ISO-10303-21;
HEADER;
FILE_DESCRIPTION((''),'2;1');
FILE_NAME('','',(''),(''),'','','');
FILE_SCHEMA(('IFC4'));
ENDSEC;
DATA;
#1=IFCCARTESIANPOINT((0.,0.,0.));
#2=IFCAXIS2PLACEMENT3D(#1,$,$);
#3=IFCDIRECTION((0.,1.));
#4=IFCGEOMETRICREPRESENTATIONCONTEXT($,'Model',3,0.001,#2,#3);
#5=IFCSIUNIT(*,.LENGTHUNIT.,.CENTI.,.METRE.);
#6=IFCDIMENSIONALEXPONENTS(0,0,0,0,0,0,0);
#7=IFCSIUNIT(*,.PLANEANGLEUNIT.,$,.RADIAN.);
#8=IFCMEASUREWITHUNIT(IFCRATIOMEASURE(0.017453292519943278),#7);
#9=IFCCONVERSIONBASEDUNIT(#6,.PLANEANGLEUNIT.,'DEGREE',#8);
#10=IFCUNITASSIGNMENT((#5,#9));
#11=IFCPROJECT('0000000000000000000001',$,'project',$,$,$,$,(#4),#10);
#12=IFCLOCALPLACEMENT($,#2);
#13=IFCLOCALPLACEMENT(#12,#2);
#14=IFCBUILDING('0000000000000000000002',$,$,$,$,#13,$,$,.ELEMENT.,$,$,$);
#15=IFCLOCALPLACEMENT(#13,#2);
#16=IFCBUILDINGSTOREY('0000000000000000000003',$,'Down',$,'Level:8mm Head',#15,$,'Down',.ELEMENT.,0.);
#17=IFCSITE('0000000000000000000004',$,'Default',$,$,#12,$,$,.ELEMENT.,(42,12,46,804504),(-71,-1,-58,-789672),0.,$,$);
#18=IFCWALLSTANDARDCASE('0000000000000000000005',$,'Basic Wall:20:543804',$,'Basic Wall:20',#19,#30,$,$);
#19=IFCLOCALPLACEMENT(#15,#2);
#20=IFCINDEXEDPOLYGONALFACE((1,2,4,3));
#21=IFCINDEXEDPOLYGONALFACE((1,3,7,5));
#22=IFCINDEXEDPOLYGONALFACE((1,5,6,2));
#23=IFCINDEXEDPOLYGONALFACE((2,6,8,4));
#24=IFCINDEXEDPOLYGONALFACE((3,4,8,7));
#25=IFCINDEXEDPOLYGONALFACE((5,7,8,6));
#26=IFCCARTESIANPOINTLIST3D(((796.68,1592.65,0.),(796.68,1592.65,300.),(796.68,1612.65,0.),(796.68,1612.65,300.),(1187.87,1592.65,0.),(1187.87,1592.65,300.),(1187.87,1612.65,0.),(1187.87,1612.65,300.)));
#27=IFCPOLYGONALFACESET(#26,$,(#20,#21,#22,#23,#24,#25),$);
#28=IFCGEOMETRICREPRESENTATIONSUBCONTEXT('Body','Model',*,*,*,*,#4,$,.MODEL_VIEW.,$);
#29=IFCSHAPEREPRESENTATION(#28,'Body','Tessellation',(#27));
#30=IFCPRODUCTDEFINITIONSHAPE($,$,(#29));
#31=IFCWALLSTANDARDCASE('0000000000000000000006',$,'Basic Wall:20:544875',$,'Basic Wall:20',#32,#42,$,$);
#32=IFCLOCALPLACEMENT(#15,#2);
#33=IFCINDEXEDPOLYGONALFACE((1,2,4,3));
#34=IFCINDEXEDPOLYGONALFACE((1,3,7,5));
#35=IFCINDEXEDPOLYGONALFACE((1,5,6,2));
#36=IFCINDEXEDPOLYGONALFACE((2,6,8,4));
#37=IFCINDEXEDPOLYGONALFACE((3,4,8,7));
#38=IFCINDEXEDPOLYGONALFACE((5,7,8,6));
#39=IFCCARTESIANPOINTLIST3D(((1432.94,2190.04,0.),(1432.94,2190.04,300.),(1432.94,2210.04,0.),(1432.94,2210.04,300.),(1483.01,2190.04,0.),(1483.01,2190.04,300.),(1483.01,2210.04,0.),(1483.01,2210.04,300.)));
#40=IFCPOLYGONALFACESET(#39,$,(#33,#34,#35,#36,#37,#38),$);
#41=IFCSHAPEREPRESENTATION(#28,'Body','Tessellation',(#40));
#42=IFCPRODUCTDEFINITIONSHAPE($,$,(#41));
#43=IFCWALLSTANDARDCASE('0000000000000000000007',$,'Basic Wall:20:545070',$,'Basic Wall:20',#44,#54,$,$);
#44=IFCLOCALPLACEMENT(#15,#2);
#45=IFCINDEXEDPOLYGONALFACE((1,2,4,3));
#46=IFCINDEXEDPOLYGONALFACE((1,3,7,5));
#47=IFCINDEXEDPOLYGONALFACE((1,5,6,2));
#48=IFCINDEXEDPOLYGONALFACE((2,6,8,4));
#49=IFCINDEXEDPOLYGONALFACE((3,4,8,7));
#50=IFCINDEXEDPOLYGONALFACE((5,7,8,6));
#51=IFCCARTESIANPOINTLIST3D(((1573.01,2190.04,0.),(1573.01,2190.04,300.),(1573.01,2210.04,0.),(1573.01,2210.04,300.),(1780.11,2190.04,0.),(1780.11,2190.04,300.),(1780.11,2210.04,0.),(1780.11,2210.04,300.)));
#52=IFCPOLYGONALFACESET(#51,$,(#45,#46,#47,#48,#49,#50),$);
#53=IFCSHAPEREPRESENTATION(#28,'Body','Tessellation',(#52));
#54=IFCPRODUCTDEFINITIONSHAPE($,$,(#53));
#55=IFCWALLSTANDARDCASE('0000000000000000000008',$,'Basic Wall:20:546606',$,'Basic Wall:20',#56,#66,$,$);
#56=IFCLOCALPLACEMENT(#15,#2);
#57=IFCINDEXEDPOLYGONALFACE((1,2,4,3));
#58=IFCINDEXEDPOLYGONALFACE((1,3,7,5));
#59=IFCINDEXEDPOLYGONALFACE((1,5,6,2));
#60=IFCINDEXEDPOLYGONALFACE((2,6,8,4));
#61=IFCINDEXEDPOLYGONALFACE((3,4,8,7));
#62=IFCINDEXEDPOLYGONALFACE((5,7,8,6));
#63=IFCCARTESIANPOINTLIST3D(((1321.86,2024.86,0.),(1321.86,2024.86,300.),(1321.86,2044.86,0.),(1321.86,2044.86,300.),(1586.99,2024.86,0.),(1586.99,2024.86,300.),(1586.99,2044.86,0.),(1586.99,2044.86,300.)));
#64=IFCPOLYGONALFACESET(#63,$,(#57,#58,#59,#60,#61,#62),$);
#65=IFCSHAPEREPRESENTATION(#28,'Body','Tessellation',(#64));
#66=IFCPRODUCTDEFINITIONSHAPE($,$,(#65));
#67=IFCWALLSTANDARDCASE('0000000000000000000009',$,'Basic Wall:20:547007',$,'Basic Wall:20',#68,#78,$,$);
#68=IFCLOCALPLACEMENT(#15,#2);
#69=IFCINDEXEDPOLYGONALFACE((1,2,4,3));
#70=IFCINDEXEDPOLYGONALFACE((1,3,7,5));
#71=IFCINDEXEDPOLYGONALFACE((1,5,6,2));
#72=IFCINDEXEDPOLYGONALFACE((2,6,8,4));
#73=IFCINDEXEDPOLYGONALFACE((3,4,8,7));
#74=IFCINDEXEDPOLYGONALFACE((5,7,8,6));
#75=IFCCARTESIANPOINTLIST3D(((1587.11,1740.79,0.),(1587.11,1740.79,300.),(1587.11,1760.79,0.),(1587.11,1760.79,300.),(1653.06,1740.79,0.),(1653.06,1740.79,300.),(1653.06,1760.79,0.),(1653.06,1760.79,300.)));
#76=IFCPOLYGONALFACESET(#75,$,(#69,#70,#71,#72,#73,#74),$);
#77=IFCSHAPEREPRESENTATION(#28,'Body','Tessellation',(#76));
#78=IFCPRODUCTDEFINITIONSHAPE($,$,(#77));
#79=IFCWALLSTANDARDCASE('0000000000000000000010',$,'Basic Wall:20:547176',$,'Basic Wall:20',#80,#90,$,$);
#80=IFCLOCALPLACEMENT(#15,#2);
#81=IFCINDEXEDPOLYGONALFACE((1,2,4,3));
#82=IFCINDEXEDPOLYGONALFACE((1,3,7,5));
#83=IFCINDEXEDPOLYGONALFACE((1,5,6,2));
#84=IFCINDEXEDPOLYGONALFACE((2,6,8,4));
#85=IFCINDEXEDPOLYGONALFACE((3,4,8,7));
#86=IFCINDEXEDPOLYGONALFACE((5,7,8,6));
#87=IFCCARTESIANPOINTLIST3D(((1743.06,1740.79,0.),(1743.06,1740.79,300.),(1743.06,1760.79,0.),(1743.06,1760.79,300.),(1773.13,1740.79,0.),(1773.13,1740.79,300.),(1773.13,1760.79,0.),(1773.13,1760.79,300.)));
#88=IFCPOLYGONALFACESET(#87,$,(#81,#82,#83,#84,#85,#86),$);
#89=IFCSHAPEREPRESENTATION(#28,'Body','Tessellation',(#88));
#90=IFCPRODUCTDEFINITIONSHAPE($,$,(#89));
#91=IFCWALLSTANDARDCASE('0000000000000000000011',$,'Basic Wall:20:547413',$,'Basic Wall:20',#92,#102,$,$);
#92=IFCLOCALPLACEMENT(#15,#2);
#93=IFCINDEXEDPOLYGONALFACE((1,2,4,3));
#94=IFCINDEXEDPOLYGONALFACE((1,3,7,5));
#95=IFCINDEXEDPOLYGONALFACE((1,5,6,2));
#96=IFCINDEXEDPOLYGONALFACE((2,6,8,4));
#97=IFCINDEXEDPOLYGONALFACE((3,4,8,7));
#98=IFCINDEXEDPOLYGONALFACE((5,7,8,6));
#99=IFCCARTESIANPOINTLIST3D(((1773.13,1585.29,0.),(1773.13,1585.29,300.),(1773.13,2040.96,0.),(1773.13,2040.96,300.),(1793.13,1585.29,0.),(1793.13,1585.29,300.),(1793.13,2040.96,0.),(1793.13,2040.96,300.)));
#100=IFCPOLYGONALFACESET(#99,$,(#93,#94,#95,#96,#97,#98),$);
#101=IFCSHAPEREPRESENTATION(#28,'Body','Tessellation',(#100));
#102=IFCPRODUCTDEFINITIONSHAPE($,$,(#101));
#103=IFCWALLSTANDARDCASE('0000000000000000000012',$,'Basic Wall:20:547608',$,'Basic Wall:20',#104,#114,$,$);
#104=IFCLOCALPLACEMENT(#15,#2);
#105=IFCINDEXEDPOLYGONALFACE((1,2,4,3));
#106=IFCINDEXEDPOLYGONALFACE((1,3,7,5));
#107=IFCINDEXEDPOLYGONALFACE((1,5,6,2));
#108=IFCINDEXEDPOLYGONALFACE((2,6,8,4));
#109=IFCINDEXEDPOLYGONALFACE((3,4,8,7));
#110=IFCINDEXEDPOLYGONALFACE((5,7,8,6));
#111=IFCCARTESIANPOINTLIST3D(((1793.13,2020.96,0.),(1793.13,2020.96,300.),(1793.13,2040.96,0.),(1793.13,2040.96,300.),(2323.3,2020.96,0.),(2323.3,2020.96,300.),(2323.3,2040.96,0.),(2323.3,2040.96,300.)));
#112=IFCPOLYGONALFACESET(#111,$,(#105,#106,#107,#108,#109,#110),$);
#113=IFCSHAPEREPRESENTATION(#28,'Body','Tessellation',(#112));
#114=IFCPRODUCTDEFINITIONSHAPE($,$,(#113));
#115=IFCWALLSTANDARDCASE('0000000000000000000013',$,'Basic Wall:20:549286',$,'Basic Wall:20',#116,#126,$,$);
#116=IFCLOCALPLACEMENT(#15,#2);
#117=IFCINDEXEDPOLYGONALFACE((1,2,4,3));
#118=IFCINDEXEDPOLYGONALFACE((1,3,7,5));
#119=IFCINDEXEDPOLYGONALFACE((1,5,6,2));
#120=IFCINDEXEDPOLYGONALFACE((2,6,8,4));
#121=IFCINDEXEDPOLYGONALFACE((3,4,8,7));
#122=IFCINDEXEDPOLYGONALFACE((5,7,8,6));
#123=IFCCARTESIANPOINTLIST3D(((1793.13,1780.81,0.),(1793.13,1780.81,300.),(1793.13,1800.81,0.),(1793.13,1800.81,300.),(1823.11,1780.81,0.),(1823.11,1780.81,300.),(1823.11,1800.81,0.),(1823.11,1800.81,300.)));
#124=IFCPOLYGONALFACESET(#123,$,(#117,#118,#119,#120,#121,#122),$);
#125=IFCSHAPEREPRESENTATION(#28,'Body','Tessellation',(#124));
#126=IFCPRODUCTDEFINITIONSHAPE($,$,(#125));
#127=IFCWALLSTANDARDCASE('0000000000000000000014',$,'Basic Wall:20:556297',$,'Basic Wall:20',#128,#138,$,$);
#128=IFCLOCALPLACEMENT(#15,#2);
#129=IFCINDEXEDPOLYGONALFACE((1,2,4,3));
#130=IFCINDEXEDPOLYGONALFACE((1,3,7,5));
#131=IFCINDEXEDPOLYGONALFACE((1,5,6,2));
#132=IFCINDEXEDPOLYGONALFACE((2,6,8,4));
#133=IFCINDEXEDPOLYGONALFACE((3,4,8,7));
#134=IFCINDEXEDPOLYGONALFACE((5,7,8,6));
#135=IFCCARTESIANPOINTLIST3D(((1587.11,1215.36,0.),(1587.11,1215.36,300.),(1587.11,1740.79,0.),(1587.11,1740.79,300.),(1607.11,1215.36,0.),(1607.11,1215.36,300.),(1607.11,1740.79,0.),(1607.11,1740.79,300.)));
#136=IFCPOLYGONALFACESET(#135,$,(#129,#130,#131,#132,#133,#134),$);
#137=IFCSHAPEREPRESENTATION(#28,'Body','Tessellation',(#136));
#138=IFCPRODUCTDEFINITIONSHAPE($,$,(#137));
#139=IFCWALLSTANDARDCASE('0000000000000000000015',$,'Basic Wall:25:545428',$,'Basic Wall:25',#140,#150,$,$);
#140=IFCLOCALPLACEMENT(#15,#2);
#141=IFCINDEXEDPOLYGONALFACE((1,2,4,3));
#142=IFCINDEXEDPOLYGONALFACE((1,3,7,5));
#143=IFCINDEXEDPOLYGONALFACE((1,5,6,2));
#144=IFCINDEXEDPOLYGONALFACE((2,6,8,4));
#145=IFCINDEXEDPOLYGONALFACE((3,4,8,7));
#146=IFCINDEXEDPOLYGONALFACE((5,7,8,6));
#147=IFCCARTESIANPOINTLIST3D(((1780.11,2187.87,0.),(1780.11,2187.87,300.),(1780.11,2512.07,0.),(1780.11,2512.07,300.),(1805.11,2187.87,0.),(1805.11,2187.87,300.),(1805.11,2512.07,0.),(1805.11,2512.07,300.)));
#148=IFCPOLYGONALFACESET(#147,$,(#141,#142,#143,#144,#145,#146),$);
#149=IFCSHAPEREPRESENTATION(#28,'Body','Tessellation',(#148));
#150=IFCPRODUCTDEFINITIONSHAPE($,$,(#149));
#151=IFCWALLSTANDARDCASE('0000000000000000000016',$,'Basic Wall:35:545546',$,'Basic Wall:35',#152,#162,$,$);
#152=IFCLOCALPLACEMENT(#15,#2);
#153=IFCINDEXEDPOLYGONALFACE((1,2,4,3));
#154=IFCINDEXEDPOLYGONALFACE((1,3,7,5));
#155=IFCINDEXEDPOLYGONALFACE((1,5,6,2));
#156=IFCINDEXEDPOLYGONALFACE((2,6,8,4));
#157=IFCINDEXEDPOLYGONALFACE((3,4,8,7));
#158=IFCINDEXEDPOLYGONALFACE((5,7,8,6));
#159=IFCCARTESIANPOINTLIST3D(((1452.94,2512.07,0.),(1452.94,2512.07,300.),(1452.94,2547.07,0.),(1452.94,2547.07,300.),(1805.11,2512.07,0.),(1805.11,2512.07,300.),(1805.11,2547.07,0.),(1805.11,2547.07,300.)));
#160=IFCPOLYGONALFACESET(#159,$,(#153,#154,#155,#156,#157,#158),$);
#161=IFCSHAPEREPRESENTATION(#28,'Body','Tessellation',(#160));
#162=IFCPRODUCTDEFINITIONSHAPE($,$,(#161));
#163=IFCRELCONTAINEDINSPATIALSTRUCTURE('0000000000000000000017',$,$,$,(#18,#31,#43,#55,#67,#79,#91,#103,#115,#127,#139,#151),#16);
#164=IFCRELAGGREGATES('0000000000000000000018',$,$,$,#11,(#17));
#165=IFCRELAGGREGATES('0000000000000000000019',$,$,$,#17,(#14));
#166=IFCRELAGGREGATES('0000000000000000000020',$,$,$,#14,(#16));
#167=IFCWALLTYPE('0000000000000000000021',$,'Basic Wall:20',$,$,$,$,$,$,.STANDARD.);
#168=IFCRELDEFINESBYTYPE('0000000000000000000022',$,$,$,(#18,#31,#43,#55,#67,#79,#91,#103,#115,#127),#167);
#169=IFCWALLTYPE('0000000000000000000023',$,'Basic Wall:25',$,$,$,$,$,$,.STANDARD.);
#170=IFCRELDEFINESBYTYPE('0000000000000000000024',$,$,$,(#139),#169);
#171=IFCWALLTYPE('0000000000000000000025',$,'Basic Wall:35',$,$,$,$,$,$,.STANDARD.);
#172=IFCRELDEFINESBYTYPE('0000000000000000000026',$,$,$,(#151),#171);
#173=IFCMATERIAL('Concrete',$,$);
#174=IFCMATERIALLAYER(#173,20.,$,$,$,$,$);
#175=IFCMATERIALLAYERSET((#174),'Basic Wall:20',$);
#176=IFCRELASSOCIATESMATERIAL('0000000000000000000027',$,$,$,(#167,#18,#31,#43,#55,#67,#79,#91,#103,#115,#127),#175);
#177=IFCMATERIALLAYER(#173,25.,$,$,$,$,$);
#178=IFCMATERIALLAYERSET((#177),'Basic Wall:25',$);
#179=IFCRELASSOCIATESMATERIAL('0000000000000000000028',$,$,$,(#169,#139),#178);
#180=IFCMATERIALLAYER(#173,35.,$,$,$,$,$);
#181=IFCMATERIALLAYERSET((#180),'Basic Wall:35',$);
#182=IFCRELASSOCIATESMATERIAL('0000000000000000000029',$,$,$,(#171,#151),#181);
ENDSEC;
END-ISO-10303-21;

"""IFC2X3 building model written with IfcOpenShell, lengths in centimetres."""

from ifc_helpers import new_model, entity, si_unit, converted_unit, direction, frame, frame_2d, origin, place, context, subcontext, project, spatial, rectangle, extrude, material, layer, layer_set, layer_usage, type_object, element, save


model = new_model("IFC2X3")

# Units and contexts
model_context = context("Model", 3, precision=0.001, world=origin(), true_north=direction((0.0, 1.0)))
body_context = subcontext(model_context, "Body", "Model", "MODEL_VIEW")
ifc_project = project(units=[si_unit("LENGTHUNIT", "METRE", prefix="CENTI"), converted_unit("PLANEANGLEUNIT", "DEGREE", entity("IfcRatioMeasure", 0.017453292519943278), si_unit("PLANEANGLEUNIT", "RADIAN"), dimensions=[0, 0, 0, 0, 0, 0, 0])], contexts=[model_context])

# Site, building, storey
site_placement = place(None, origin())
site = spatial("IfcSite", under=ifc_project, at=site_placement, Name="Default", CompositionType="ELEMENT", RefLatitude=(42, 12, 46, 804504), RefLongitude=(-71, -1, -58, -789672), RefElevation=0.0)
building_placement = place(site_placement, origin())
building = spatial("IfcBuilding", under=site, at=building_placement, CompositionType="ELEMENT")
storey_placement = place(building_placement, origin())
storey = spatial("IfcBuildingStorey", under=building, at=storey_placement, Name="Down", ObjectType="Level:8mm Head", LongName="Down", CompositionType="ELEMENT", Elevation=0.0)

# Walls
ifc_material = material(Name="Concrete")
ifc_layer_1 = layer(ifc_material, 20.0)
ifc_layer_set_1 = layer_set([ifc_layer_1], Name="Basic Wall:20")
wall_type_1 = type_object("IfcWallType", Name="Basic Wall:20", PredefinedType="STANDARD", material=ifc_layer_set_1)
ifc_layer_usage_1 = layer_usage(ifc_layer_set_1, "AXIS2", "POSITIVE", -10.0)
wall_1_placement = place(storey_placement, frame((796.68, 1602.65, 0.0)))
element("IfcWallStandardCase", 1, at=wall_1_placement, inside=storey, type_object=wall_type_1, material=ifc_layer_usage_1, Name="Basic Wall:20:543804", ObjectType="Basic Wall:20", context=body_context, shape_type="SweptSolid", body=[
    extrude(rectangle(XDim=391.19, YDim=20.0, at=frame_2d((195.6, 0.0), x_axis=(-1.0, 0.0))), origin(), (0.0, 0.0, 1.0), 300.0),
])
ifc_layer_usage_2 = layer_usage(ifc_layer_set_1, "AXIS2", "POSITIVE", -10.0)
wall_2_placement = place(storey_placement, frame((1432.94, 2200.04, 0.0)))
element("IfcWallStandardCase", 2, at=wall_2_placement, inside=storey, type_object=wall_type_1, material=ifc_layer_usage_2, Name="Basic Wall:20:544875", ObjectType="Basic Wall:20", context=body_context, shape_type="SweptSolid", body=[
    extrude(rectangle(XDim=50.07, YDim=20.0, at=frame_2d((25.04, 0.0), x_axis=(-1.0, 0.0))), origin(), (0.0, 0.0, 1.0), 300.0),
])
ifc_layer_usage_3 = layer_usage(ifc_layer_set_1, "AXIS2", "POSITIVE", -10.0)
wall_3_placement = place(storey_placement, frame((1573.01, 2200.04, 0.0)))
element("IfcWallStandardCase", 3, at=wall_3_placement, inside=storey, type_object=wall_type_1, material=ifc_layer_usage_3, Name="Basic Wall:20:545070", ObjectType="Basic Wall:20", context=body_context, shape_type="SweptSolid", body=[
    extrude(rectangle(XDim=207.1, YDim=20.0, at=frame_2d((103.55, 0.0), x_axis=(-1.0, 0.0))), origin(), (0.0, 0.0, 1.0), 300.0),
])
ifc_layer_usage_4 = layer_usage(ifc_layer_set_1, "AXIS2", "POSITIVE", -10.0)
wall_4_placement = place(storey_placement, frame((1321.86, 2034.86, 0.0)))
element("IfcWallStandardCase", 4, at=wall_4_placement, inside=storey, type_object=wall_type_1, material=ifc_layer_usage_4, Name="Basic Wall:20:546606", ObjectType="Basic Wall:20", context=body_context, shape_type="SweptSolid", body=[
    extrude(rectangle(XDim=265.13, YDim=20.0, at=frame_2d((132.57, 0.0), x_axis=(-1.0, 0.0))), origin(), (0.0, 0.0, 1.0), 300.0),
])
ifc_layer_usage_5 = layer_usage(ifc_layer_set_1, "AXIS2", "NEGATIVE", 10.0)
wall_5_placement = place(storey_placement, frame((1587.11, 1750.79, 0.0)))
element("IfcWallStandardCase", 5, at=wall_5_placement, inside=storey, type_object=wall_type_1, material=ifc_layer_usage_5, Name="Basic Wall:20:547007", ObjectType="Basic Wall:20", context=body_context, shape_type="SweptSolid", body=[
    extrude(rectangle(XDim=65.95, YDim=20.0, at=frame_2d((32.98, 0.0), x_axis=(-1.0, 0.0))), origin(), (0.0, 0.0, 1.0), 300.0),
])
ifc_layer_usage_6 = layer_usage(ifc_layer_set_1, "AXIS2", "NEGATIVE", 10.0)
wall_6_placement = place(storey_placement, frame((1743.06, 1750.79, 0.0)))
element("IfcWallStandardCase", 6, at=wall_6_placement, inside=storey, type_object=wall_type_1, material=ifc_layer_usage_6, Name="Basic Wall:20:547176", ObjectType="Basic Wall:20", context=body_context, shape_type="SweptSolid", body=[
    extrude(rectangle(XDim=30.07, YDim=20.0, at=frame_2d((15.04, 0.0), x_axis=(-1.0, 0.0))), origin(), (0.0, 0.0, 1.0), 300.0),
])
ifc_layer_usage_7 = layer_usage(ifc_layer_set_1, "AXIS2", "NEGATIVE", 10.0)
wall_7_placement = place(storey_placement, frame((1783.13, 1585.29, 0.0), z_axis=(0.0, 0.0, 1.0), x_axis=(0.0, 1.0, 0.0)))
element("IfcWallStandardCase", 7, at=wall_7_placement, inside=storey, type_object=wall_type_1, material=ifc_layer_usage_7, Name="Basic Wall:20:547413", ObjectType="Basic Wall:20", context=body_context, shape_type="SweptSolid", body=[
    extrude(rectangle(XDim=455.67, YDim=20.0, at=frame_2d((227.83, 0.0), x_axis=(-1.0, 0.0))), origin(), (0.0, 0.0, 1.0), 300.0),
])
ifc_layer_usage_8 = layer_usage(ifc_layer_set_1, "AXIS2", "NEGATIVE", 10.0)
wall_8_placement = place(storey_placement, frame((1793.13, 2030.96, 0.0)))
element("IfcWallStandardCase", 8, at=wall_8_placement, inside=storey, type_object=wall_type_1, material=ifc_layer_usage_8, Name="Basic Wall:20:547608", ObjectType="Basic Wall:20", context=body_context, shape_type="SweptSolid", body=[
    extrude(rectangle(XDim=530.17, YDim=20.0, at=frame_2d((265.09, 0.0), x_axis=(-1.0, 0.0))), origin(), (0.0, 0.0, 1.0), 300.0),
])
ifc_layer_usage_9 = layer_usage(ifc_layer_set_1, "AXIS2", "POSITIVE", -10.0)
wall_9_placement = place(storey_placement, frame((1823.11, 1790.81, 0.0), z_axis=(0.0, 0.0, 1.0), x_axis=(-1.0, 0.0, 0.0)))
element("IfcWallStandardCase", 9, at=wall_9_placement, inside=storey, type_object=wall_type_1, material=ifc_layer_usage_9, Name="Basic Wall:20:549286", ObjectType="Basic Wall:20", context=body_context, shape_type="SweptSolid", body=[
    extrude(rectangle(XDim=29.98, YDim=20.0, at=frame_2d((14.99, 0.0), x_axis=(-1.0, 0.0))), origin(), (0.0, 0.0, 1.0), 300.0),
])
ifc_layer_usage_10 = layer_usage(ifc_layer_set_1, "AXIS2", "NEGATIVE", 10.0)
wall_10_placement = place(storey_placement, frame((1597.11, 1740.79, 0.0), z_axis=(0.0, 0.0, 1.0), x_axis=(0.0, -1.0, 0.0)))
element("IfcWallStandardCase", 10, at=wall_10_placement, inside=storey, type_object=wall_type_1, material=ifc_layer_usage_10, Name="Basic Wall:20:556297", ObjectType="Basic Wall:20", context=body_context, shape_type="SweptSolid", body=[
    extrude(rectangle(XDim=525.43, YDim=20.0, at=frame_2d((262.71, 0.0), x_axis=(-1.0, 0.0))), origin(), (0.0, 0.0, 1.0), 300.0),
])
ifc_layer_2 = layer(ifc_material, 25.0)
ifc_layer_set_2 = layer_set([ifc_layer_2], Name="Basic Wall:25")
ifc_layer_usage_11 = layer_usage(ifc_layer_set_2, "AXIS2", "POSITIVE", -12.5)
wall_type_2 = type_object("IfcWallType", Name="Basic Wall:25", PredefinedType="STANDARD", material=ifc_layer_set_2)
wall_11_placement = place(storey_placement, frame((1792.61, 2187.87, 0.0), z_axis=(0.0, 0.0, 1.0), x_axis=(0.0, 1.0, 0.0)))
element("IfcWallStandardCase", 11, at=wall_11_placement, inside=storey, type_object=wall_type_2, material=ifc_layer_usage_11, Name="Basic Wall:25:545428", ObjectType="Basic Wall:25", context=body_context, shape_type="SweptSolid", body=[
    extrude(rectangle(XDim=324.21, YDim=25.0, at=frame_2d((162.1, 0.0), x_axis=(-1.0, 0.0))), origin(), (0.0, 0.0, 1.0), 300.0),
])
ifc_layer_3 = layer(ifc_material, 35.0)
ifc_layer_set_3 = layer_set([ifc_layer_3], Name="Basic Wall:35")
ifc_layer_usage_12 = layer_usage(ifc_layer_set_3, "AXIS2", "POSITIVE", -17.5)
wall_type_3 = type_object("IfcWallType", Name="Basic Wall:35", PredefinedType="STANDARD", material=ifc_layer_set_3)
wall_12_placement = place(storey_placement, frame((1805.11, 2529.57, 0.0), z_axis=(0.0, 0.0, 1.0), x_axis=(-1.0, 0.0, 0.0)))
element("IfcWallStandardCase", 12, at=wall_12_placement, inside=storey, type_object=wall_type_3, material=ifc_layer_usage_12, Name="Basic Wall:35:545546", ObjectType="Basic Wall:35", context=body_context, shape_type="SweptSolid", body=[
    extrude(rectangle(XDim=352.17, YDim=35.0, at=frame_2d((176.08, 0.0), x_axis=(-1.0, 0.0))), origin(), (0.0, 0.0, 1.0), 300.0),
])

save(model, "model.ifc")
